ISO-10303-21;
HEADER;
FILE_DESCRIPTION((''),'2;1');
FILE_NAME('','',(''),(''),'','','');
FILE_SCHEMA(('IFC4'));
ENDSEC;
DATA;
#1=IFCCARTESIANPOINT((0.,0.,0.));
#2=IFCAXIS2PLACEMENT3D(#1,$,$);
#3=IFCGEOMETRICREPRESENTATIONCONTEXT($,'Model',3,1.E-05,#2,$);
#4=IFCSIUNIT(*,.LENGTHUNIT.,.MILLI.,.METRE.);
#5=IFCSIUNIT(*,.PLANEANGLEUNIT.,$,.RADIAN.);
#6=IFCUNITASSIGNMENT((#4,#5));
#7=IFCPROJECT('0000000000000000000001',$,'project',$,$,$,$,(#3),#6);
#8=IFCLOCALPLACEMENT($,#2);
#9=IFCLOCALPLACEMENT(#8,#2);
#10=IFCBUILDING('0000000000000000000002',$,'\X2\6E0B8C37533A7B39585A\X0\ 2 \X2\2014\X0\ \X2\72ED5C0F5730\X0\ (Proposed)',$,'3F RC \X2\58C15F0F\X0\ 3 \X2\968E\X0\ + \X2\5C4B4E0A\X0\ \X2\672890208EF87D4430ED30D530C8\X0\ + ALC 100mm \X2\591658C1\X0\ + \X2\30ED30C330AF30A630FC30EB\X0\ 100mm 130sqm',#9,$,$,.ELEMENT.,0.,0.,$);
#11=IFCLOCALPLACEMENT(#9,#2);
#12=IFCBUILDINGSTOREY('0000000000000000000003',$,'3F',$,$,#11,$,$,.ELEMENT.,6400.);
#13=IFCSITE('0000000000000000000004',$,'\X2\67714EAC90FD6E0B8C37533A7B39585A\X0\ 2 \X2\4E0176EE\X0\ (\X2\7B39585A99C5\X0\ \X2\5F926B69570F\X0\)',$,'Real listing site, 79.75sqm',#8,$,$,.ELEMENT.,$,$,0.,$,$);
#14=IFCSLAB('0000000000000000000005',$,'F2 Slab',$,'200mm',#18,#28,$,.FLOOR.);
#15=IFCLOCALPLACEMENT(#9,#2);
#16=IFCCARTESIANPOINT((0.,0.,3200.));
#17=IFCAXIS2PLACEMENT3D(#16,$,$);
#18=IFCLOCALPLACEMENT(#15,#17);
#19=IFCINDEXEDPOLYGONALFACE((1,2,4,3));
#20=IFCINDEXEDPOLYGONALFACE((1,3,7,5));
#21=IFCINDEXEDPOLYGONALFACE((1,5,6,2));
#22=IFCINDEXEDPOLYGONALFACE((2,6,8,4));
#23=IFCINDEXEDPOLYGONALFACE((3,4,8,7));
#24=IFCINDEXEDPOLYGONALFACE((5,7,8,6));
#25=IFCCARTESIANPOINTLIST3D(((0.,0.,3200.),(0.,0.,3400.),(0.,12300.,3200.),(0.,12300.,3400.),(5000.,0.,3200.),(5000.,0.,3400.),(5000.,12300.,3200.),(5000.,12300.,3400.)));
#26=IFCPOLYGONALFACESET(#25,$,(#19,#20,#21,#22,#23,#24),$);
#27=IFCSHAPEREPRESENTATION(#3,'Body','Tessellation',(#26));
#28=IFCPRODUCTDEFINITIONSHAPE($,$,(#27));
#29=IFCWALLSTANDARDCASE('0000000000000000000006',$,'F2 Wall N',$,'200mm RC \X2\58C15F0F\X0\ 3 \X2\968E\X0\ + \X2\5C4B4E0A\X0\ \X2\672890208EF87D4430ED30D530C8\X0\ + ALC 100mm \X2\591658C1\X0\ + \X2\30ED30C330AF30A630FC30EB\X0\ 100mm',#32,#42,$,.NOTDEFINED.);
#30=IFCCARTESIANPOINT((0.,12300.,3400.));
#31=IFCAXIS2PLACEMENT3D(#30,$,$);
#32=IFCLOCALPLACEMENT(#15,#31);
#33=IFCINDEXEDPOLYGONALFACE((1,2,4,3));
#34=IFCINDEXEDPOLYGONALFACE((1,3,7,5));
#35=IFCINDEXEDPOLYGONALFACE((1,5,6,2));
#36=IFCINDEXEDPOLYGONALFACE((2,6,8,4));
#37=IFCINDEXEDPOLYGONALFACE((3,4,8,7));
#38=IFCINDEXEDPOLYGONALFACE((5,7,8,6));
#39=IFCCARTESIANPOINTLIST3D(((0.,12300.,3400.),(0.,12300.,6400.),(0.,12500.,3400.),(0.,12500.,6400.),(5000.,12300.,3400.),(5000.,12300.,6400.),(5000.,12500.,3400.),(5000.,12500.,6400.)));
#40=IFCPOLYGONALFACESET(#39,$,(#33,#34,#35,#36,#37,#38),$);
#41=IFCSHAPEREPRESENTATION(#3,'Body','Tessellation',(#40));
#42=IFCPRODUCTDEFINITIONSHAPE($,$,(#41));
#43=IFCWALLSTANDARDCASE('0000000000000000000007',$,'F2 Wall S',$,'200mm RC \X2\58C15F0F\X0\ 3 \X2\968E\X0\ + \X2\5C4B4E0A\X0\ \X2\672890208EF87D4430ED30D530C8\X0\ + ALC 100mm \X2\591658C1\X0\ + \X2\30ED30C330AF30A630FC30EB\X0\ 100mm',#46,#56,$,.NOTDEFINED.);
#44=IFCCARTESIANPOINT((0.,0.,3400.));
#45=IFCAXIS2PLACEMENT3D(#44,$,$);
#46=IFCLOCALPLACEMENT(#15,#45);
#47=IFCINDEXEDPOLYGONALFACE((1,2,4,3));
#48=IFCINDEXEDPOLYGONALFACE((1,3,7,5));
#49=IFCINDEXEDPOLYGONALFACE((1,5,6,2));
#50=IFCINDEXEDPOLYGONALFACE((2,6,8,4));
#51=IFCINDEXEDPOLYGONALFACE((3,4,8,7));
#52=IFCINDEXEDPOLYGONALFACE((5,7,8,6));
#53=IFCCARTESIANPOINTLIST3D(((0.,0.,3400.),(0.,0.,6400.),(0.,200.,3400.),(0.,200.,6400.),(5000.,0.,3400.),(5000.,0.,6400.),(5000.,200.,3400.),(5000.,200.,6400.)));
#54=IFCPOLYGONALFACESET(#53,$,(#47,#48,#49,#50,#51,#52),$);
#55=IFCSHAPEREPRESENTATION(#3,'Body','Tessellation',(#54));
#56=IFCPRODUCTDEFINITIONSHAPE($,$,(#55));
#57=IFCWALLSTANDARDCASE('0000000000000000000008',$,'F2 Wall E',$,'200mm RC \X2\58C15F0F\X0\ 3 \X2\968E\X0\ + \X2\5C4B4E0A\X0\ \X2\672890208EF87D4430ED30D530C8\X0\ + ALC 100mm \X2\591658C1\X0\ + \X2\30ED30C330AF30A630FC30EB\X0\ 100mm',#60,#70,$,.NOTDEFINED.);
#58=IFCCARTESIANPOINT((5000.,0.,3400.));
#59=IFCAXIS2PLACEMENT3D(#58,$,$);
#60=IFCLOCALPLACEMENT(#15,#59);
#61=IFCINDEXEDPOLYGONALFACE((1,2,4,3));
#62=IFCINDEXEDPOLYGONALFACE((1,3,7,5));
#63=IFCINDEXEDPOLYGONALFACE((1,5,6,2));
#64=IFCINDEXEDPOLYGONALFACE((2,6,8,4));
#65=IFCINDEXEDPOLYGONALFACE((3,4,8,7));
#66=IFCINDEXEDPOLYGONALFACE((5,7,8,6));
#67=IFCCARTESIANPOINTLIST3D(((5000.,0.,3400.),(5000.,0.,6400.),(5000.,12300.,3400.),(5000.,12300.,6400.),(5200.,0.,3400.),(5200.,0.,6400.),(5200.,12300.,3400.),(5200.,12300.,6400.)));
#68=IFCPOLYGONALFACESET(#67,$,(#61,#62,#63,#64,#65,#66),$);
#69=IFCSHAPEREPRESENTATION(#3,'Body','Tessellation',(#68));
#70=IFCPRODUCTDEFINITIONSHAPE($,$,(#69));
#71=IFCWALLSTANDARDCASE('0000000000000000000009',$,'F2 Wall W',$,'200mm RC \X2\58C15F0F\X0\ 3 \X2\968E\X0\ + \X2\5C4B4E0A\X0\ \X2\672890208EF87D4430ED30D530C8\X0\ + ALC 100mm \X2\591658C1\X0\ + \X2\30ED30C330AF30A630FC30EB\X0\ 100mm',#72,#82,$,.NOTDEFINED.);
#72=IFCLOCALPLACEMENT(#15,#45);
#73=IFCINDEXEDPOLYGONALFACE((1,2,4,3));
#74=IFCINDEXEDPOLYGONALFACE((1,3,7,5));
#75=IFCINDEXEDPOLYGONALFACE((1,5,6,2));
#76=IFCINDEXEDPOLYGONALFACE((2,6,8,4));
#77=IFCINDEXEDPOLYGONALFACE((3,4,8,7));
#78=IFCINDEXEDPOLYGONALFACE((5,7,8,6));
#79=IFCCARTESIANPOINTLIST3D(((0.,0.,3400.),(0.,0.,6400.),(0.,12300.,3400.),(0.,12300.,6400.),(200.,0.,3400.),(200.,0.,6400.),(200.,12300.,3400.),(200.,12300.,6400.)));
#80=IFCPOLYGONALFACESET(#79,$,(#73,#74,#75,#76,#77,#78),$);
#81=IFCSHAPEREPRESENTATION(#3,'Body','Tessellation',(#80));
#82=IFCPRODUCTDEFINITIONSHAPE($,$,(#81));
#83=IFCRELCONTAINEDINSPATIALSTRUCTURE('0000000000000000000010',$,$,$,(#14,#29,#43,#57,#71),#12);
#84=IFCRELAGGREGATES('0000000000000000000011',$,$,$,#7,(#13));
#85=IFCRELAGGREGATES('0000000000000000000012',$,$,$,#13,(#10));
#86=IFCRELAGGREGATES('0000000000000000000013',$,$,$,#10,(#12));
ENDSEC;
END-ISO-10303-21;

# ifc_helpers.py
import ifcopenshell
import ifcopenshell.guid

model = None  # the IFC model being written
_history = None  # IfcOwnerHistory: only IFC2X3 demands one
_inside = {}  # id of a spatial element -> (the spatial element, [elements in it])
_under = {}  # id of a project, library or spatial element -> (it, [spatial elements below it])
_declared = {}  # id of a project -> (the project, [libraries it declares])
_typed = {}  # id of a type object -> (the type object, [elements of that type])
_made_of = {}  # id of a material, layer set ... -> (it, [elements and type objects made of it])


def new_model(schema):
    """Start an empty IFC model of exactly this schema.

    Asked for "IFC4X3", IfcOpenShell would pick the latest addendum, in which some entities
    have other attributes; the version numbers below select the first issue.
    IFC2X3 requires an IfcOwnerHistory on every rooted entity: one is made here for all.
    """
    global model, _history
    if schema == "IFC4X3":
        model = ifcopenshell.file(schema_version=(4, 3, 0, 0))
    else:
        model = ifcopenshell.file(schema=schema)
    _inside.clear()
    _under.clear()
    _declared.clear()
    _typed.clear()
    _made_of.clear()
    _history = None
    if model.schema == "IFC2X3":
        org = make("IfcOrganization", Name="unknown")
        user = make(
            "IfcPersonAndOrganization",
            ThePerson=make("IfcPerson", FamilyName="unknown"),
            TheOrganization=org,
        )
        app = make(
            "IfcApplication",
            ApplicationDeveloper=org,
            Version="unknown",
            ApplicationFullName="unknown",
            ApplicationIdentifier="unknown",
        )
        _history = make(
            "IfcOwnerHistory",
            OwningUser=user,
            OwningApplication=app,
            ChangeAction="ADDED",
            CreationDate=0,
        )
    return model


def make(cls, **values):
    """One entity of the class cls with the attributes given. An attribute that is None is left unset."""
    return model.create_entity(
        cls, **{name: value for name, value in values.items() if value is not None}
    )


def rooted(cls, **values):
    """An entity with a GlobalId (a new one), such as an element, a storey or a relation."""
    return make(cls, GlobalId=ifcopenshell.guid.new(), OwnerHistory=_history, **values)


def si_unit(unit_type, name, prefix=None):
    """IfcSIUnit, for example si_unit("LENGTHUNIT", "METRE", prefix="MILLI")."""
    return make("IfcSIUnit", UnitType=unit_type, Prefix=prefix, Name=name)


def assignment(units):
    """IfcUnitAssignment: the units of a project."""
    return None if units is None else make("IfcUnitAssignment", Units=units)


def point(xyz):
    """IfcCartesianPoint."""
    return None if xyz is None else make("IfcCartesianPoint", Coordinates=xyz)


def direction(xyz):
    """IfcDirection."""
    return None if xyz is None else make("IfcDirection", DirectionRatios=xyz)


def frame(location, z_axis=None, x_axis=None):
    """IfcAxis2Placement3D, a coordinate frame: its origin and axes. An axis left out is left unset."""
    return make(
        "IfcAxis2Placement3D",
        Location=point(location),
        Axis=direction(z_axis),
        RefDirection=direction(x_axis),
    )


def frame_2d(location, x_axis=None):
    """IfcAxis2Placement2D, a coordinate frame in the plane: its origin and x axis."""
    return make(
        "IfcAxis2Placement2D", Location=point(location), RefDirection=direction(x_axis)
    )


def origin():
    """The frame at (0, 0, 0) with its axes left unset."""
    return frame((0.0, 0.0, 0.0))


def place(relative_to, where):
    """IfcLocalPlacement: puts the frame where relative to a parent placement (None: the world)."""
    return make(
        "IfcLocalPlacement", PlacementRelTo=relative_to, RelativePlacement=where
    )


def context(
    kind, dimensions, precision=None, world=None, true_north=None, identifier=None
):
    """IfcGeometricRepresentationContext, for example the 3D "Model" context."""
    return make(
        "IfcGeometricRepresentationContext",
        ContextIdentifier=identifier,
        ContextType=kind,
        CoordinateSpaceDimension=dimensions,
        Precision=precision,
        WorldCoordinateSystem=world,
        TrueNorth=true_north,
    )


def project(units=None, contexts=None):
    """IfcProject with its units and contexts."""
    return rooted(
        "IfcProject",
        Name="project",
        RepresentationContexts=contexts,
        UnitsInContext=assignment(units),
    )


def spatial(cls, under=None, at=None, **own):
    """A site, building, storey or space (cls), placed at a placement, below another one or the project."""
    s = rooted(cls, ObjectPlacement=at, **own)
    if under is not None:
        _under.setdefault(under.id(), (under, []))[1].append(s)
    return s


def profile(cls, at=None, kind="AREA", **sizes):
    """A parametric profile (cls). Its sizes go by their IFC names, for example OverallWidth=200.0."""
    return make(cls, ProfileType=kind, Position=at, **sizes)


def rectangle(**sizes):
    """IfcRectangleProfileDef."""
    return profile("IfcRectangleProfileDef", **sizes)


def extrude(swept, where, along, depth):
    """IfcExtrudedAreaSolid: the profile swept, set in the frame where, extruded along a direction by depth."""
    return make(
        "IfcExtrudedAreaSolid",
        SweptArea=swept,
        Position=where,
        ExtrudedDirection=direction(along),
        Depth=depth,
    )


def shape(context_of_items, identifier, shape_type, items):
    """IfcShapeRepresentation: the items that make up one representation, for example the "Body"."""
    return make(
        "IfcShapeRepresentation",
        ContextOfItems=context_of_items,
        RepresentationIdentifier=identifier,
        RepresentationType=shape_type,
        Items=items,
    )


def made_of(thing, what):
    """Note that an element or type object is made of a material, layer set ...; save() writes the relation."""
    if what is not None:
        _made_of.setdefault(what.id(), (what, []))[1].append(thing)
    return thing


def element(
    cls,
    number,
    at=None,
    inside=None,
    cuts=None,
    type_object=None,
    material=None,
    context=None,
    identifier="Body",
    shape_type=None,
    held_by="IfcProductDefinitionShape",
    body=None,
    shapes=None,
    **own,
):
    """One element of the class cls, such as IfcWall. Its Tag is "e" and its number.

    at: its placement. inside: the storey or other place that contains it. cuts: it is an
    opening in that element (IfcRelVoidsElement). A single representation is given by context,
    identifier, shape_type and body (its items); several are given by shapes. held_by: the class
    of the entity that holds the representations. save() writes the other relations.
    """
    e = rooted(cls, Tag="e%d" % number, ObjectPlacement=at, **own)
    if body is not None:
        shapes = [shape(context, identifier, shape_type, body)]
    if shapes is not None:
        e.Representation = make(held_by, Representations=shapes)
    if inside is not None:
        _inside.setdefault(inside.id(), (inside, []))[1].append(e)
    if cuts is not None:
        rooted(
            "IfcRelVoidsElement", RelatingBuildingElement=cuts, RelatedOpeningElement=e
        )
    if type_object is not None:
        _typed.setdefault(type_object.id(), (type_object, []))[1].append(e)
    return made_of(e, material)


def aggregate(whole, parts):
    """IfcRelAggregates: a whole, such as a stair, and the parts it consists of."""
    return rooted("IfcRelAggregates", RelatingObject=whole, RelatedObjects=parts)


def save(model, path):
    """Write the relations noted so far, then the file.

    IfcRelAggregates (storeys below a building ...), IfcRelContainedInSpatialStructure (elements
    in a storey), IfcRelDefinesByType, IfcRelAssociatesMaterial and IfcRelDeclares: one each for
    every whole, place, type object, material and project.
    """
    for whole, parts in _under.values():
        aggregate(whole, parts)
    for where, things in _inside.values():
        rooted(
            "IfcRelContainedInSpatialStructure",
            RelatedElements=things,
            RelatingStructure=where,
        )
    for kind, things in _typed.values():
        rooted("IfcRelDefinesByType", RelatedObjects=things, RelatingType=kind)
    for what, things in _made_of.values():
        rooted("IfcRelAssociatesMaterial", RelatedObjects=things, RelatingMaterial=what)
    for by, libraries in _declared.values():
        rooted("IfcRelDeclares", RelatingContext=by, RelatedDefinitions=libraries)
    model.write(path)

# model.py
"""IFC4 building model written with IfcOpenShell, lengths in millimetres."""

from ifc_helpers import new_model, si_unit, frame, frame_2d, origin, place, context, project, spatial, rectangle, extrude, element, save


model = new_model("IFC4")

# Units and contexts
model_context = context("Model", 3, precision=1e-05, world=origin())
ifc_project = project(units=[si_unit("LENGTHUNIT", "METRE", prefix="MILLI"), si_unit("PLANEANGLEUNIT", "RADIAN")], contexts=[model_context])

# Site, building, storey
site_placement = place(None, origin())
site = spatial("IfcSite", under=ifc_project, at=site_placement, Name="東京都渋谷区笹塚 2 丁目 (笹塚駅 徒歩圏)", ObjectType="Real listing site, 79.75sqm", CompositionType="ELEMENT", RefElevation=0.0)
building_placement = place(site_placement, origin())
building = spatial("IfcBuilding", under=site, at=building_placement, Name="渋谷区笹塚 2 — 狭小地 (Proposed)", ObjectType="3F RC 壁式 3 階 + 屋上 木造軸組ロフト + ALC 100mm 外壁 + ロックウール 100mm 130sqm", CompositionType="ELEMENT", ElevationOfRefHeight=0.0, ElevationOfTerrain=0.0)
storey_placement = place(building_placement, origin())
storey = spatial("IfcBuildingStorey", under=building, at=storey_placement, Name="3F", CompositionType="ELEMENT", Elevation=6400.0)

# Slab
placement = place(building_placement, origin())
slab_placement = place(placement, frame((0.0, 0.0, 3200.0)))
element("IfcSlab", 1, at=slab_placement, inside=storey, Name="F2 Slab", ObjectType="200mm", PredefinedType="FLOOR", context=model_context, shape_type="SweptSolid", body=[
    extrude(rectangle(XDim=5000.0, YDim=12300.0, at=frame_2d((2500.0, 6150.0))), frame((0.0, 0.0, 3200.0)), (0.0, 0.0, 1.0), 200.0),
])

# Walls
wall_1_placement = place(placement, frame((0.0, 12300.0, 3400.0)))
element("IfcWallStandardCase", 2, at=wall_1_placement, inside=storey, Name="F2 Wall N", ObjectType="200mm RC 壁式 3 階 + 屋上 木造軸組ロフト + ALC 100mm 外壁 + ロックウール 100mm", PredefinedType="NOTDEFINED", context=model_context, shape_type="SweptSolid", body=[
    extrude(rectangle(XDim=5000.0, YDim=200.0, at=frame_2d((2500.0, 100.0))), frame((0.0, 12300.0, 3400.0)), (0.0, 0.0, 1.0), 3000.0),
])
wall_2_placement = place(placement, frame((0.0, 0.0, 3400.0)))
element("IfcWallStandardCase", 3, at=wall_2_placement, inside=storey, Name="F2 Wall S", ObjectType="200mm RC 壁式 3 階 + 屋上 木造軸組ロフト + ALC 100mm 外壁 + ロックウール 100mm", PredefinedType="NOTDEFINED", context=model_context, shape_type="SweptSolid", body=[
    extrude(rectangle(XDim=5000.0, YDim=200.0, at=frame_2d((2500.0, 100.0))), frame((0.0, 0.0, 3400.0)), (0.0, 0.0, 1.0), 3000.0),
])
wall_3_placement = place(placement, frame((5000.0, 0.0, 3400.0)))
element("IfcWallStandardCase", 4, at=wall_3_placement, inside=storey, Name="F2 Wall E", ObjectType="200mm RC 壁式 3 階 + 屋上 木造軸組ロフト + ALC 100mm 外壁 + ロックウール 100mm", PredefinedType="NOTDEFINED", context=model_context, shape_type="SweptSolid", body=[
    extrude(rectangle(XDim=200.0, YDim=12300.0, at=frame_2d((100.0, 6150.0))), frame((5000.0, 0.0, 3400.0)), (0.0, 0.0, 1.0), 3000.0),
])
wall_4_placement = place(placement, frame((0.0, 0.0, 3400.0)))
element("IfcWallStandardCase", 5, at=wall_4_placement, inside=storey, Name="F2 Wall W", ObjectType="200mm RC 壁式 3 階 + 屋上 木造軸組ロフト + ALC 100mm 外壁 + ロックウール 100mm", PredefinedType="NOTDEFINED", context=model_context, shape_type="SweptSolid", body=[
    extrude(rectangle(XDim=200.0, YDim=12300.0, at=frame_2d((100.0, 6150.0))), frame((0.0, 0.0, 3400.0)), (0.0, 0.0, 1.0), 3000.0),
])

save(model, "model.ifc")
